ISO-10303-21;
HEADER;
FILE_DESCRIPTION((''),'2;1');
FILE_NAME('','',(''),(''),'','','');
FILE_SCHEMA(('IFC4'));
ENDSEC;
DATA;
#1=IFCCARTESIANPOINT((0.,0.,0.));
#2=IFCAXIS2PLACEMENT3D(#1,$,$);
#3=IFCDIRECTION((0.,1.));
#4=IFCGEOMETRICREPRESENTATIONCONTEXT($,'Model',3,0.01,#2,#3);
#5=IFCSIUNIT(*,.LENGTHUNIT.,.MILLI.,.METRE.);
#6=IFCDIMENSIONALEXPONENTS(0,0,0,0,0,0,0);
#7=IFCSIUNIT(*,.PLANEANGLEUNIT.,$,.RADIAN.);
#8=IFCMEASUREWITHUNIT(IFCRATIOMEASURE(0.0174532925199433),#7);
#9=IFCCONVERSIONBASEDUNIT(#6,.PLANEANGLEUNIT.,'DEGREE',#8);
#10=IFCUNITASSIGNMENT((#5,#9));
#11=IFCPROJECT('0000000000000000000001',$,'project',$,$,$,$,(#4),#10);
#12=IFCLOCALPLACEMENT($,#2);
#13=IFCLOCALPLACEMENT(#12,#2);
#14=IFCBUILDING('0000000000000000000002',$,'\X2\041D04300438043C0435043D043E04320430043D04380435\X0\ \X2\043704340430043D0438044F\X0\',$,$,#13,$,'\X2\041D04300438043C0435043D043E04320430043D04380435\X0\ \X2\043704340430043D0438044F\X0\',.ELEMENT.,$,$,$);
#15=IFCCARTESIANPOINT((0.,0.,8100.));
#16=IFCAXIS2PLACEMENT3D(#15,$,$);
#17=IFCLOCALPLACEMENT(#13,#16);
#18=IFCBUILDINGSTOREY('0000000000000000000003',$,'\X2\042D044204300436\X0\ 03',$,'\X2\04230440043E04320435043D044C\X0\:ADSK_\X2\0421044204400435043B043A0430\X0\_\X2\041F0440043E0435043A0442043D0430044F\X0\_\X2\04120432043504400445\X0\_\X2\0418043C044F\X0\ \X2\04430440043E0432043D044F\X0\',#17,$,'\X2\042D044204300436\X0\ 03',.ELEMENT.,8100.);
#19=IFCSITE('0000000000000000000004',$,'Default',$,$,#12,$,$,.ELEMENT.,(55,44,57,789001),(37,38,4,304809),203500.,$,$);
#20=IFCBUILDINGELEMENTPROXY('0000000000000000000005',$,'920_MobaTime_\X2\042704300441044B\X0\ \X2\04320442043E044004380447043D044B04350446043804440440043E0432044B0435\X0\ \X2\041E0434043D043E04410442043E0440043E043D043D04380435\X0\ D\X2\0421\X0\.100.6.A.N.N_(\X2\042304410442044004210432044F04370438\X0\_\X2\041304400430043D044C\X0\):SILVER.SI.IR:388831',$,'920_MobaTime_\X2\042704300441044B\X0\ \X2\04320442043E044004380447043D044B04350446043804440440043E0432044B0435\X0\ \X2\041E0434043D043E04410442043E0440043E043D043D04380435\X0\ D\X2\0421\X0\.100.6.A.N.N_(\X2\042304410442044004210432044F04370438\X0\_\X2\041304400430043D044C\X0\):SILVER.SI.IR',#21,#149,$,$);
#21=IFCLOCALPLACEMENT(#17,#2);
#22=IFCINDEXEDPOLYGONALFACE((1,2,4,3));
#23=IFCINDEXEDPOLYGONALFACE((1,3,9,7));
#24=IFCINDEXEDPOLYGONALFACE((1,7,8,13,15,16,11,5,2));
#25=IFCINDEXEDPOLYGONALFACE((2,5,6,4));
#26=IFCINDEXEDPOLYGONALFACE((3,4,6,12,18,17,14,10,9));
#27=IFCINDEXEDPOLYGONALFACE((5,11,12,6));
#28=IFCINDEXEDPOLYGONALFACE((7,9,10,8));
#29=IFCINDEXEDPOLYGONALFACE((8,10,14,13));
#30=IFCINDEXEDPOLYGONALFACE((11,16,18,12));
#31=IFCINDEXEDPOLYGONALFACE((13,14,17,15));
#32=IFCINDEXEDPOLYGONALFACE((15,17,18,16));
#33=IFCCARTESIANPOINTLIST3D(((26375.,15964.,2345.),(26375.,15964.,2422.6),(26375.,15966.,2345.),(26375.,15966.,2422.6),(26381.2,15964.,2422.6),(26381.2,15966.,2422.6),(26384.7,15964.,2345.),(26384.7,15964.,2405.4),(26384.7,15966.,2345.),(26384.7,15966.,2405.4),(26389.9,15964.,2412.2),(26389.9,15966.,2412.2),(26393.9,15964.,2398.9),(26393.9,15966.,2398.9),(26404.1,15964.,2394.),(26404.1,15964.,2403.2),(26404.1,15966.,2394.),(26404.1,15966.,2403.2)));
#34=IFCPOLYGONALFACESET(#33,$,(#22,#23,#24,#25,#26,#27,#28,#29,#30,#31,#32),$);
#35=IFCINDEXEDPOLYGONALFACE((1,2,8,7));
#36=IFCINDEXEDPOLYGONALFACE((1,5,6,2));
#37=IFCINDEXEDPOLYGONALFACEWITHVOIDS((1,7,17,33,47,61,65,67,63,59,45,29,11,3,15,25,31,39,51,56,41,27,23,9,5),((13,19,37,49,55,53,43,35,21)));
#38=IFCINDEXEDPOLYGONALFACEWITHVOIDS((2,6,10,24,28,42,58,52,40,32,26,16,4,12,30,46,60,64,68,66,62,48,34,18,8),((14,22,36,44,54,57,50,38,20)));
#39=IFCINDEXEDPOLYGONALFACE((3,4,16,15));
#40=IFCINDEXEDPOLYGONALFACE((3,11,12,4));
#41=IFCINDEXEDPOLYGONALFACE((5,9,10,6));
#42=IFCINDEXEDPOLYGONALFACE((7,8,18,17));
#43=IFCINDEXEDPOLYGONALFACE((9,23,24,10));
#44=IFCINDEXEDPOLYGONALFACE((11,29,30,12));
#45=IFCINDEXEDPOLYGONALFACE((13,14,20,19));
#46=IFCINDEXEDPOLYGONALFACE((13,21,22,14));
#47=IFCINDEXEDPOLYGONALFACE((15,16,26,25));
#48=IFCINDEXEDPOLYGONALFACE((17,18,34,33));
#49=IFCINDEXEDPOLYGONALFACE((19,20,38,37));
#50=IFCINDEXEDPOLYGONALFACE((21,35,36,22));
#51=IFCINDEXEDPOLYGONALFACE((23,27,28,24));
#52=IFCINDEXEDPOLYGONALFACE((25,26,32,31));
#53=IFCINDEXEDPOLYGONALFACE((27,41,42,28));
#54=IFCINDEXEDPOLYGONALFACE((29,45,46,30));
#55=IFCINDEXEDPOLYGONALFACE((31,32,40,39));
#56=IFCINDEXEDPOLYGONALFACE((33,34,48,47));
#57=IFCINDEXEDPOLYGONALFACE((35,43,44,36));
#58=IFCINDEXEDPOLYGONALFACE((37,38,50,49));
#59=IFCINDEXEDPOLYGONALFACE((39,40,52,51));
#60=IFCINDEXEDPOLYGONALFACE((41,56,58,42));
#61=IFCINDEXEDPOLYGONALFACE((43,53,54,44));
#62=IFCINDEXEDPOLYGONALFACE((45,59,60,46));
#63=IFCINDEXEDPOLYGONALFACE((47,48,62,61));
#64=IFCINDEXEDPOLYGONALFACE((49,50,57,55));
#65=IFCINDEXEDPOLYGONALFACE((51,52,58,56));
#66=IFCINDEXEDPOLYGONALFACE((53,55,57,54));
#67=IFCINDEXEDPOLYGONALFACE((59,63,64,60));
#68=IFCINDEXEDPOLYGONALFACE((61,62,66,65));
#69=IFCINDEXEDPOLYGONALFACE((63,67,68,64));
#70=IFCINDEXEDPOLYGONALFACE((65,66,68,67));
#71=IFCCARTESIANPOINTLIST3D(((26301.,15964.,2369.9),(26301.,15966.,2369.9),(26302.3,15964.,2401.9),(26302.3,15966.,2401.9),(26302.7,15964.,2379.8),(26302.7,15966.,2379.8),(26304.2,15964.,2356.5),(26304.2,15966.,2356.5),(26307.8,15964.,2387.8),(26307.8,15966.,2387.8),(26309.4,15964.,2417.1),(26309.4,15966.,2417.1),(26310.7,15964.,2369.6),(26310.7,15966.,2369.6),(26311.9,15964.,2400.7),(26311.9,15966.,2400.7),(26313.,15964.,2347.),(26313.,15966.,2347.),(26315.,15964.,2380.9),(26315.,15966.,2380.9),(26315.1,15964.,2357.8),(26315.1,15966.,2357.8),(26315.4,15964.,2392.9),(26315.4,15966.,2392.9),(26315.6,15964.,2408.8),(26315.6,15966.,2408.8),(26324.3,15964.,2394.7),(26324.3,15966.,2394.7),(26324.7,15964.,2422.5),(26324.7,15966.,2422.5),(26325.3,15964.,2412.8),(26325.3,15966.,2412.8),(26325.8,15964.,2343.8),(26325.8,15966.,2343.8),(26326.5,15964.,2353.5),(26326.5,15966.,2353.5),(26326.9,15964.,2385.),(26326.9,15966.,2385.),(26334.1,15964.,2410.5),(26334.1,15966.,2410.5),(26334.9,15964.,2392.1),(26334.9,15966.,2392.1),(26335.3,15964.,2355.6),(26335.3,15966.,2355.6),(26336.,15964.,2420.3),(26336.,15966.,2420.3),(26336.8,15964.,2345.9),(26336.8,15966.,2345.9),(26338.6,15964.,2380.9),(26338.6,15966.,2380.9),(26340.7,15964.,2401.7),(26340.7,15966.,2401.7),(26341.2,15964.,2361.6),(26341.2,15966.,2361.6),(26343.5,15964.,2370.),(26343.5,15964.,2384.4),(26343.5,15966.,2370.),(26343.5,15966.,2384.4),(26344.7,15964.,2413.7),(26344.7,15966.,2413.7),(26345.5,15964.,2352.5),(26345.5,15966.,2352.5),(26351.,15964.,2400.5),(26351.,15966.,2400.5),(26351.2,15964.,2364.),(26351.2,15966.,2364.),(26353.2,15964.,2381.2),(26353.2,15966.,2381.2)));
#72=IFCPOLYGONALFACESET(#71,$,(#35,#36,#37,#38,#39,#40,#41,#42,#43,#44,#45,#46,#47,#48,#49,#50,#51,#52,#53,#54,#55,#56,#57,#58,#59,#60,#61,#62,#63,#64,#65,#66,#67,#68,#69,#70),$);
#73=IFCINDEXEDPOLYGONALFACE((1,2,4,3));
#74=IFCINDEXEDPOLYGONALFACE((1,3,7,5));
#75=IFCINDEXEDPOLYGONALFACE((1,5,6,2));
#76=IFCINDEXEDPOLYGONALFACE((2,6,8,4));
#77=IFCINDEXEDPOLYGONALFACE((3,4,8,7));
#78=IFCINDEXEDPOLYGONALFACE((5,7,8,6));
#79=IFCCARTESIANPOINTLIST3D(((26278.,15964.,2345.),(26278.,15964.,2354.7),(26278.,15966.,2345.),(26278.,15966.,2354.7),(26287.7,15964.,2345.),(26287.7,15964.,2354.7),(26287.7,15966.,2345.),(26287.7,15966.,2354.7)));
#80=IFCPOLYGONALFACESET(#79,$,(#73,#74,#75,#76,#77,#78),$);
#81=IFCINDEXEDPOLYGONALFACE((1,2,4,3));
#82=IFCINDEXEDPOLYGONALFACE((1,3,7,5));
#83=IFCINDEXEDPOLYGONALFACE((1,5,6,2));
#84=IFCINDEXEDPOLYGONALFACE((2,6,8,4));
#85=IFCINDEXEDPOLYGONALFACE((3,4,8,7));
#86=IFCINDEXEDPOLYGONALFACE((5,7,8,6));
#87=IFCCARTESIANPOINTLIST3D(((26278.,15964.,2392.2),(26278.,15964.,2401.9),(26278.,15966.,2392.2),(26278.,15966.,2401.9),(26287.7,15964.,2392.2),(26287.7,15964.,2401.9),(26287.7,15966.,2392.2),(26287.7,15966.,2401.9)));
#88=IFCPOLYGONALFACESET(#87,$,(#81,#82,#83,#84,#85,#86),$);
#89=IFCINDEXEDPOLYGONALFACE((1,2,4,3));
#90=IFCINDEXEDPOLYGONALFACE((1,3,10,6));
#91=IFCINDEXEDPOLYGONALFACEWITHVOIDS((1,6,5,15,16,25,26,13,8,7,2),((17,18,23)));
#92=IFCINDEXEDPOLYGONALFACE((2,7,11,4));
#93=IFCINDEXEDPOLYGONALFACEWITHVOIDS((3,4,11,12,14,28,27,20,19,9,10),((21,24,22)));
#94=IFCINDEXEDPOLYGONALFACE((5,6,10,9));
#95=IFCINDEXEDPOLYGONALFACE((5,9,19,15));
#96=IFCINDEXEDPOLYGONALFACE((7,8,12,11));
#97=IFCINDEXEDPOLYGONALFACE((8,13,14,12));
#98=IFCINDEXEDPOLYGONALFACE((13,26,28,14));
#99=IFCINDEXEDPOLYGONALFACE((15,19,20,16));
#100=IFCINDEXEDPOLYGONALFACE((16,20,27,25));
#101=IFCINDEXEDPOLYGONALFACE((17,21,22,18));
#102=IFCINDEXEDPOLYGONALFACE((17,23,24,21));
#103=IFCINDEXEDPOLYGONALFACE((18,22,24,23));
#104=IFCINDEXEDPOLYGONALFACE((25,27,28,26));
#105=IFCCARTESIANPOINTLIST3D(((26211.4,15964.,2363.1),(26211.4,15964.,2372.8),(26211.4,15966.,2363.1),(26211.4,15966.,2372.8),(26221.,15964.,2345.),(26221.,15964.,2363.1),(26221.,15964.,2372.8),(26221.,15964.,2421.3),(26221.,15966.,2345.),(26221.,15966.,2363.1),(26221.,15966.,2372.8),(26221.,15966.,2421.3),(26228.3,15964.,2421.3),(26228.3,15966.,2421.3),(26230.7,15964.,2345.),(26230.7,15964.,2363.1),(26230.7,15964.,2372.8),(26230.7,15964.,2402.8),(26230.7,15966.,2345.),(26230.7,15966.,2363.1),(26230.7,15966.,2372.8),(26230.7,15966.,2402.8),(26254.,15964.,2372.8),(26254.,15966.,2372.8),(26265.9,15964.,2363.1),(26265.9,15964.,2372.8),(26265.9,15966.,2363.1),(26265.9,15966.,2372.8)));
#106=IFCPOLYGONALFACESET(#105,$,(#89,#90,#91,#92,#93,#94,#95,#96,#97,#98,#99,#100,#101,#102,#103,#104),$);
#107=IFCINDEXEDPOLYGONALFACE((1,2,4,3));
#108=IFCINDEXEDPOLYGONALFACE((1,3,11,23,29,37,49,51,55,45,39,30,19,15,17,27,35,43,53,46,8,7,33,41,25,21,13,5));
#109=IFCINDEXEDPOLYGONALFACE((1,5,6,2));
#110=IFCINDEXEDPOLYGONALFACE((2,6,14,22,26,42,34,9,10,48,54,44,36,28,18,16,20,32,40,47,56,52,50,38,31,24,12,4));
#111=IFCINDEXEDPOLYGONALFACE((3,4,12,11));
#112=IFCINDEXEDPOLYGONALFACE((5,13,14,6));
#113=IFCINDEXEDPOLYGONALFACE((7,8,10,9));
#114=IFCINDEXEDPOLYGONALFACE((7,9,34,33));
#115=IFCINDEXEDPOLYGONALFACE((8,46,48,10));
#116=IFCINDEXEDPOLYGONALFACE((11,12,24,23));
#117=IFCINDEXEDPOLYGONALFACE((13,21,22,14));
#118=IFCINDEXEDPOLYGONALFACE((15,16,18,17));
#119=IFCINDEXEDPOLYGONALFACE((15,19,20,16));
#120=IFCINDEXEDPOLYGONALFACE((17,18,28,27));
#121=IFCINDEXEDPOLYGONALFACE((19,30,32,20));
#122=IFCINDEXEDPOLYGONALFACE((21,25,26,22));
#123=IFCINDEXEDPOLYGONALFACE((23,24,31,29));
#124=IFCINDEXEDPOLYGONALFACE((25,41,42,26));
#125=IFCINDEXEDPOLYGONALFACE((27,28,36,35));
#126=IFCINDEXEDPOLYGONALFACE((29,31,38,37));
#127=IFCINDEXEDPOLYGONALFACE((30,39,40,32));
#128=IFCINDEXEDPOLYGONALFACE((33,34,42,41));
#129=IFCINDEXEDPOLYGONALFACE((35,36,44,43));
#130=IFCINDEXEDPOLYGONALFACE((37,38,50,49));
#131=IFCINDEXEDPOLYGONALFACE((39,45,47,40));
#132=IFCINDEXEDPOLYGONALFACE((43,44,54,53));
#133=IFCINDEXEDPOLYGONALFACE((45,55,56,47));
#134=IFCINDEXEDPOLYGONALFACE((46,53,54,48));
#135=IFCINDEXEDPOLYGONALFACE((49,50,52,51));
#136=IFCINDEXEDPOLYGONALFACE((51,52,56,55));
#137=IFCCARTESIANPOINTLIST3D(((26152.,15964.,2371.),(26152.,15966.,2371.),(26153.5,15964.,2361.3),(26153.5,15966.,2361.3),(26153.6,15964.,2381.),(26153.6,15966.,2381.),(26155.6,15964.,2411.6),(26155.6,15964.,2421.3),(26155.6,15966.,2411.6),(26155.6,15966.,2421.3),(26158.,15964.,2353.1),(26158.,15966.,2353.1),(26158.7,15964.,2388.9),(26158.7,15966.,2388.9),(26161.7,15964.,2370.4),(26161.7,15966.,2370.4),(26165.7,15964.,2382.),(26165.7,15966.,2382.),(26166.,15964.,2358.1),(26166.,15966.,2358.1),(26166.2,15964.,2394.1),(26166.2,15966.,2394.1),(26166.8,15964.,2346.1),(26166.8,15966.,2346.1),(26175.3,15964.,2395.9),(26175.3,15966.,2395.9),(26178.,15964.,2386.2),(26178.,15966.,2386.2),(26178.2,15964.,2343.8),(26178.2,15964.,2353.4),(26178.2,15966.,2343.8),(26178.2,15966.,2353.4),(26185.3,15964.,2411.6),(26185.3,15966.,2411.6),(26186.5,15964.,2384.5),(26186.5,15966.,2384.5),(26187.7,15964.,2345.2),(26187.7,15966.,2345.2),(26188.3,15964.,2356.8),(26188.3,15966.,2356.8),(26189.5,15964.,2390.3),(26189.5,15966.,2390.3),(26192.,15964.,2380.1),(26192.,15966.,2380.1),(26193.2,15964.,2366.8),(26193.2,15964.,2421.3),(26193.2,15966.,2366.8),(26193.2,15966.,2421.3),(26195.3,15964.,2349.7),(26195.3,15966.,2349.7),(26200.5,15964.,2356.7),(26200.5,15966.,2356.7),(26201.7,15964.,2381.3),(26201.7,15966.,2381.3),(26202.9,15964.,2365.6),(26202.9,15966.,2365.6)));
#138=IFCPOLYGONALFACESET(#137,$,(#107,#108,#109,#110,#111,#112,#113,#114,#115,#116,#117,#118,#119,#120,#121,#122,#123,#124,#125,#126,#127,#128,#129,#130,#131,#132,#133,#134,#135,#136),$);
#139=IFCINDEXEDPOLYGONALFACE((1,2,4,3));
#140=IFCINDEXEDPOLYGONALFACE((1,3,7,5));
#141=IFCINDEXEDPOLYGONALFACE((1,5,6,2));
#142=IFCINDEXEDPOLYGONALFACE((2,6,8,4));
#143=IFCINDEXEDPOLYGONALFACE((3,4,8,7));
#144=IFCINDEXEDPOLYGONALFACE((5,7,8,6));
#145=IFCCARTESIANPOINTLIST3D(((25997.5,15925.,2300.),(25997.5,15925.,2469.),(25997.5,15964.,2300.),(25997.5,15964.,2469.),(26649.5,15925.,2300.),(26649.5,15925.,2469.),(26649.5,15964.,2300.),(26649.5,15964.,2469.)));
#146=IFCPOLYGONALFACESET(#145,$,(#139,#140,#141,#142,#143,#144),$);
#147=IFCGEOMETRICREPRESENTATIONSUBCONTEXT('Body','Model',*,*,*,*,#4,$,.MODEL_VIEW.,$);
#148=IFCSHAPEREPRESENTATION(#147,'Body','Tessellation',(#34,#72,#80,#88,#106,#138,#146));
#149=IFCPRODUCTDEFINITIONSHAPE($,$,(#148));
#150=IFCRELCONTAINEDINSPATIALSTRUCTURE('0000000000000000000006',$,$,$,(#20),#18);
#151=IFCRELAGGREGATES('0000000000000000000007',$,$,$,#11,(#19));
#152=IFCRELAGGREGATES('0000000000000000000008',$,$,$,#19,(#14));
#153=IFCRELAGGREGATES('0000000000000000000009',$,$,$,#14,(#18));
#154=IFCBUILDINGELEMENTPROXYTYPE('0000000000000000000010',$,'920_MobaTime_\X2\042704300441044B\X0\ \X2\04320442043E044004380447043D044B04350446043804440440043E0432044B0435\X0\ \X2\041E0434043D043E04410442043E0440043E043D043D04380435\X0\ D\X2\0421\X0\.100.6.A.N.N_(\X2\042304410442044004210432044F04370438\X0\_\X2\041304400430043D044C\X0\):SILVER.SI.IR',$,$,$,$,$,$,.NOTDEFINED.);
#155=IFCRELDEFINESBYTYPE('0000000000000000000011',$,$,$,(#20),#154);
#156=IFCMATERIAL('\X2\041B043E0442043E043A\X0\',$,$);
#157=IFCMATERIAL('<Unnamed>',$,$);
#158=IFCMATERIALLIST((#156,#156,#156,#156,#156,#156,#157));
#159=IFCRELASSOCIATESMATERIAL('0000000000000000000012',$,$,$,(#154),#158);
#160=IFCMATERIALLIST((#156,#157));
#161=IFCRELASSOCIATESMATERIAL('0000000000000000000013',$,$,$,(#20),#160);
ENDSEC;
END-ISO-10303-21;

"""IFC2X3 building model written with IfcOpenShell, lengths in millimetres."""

from ifc_helpers import new_model, entity, si_unit, converted_unit, direction, frame, origin, origin_2d_with_axis, place, context, subcontext, project, spatial, polyline, rectangle, outline, extrude, source, transform, mapped, material, material_list, type_object, type_shapes, element, save


model = new_model("IFC2X3")

# Units and contexts
model_context = context("Model", 3, precision=0.01, world=origin(), true_north=direction((0.0, 1.0)))
body_context = subcontext(model_context, "Body", "Model", "MODEL_VIEW")
ifc_project = project(units=[si_unit("LENGTHUNIT", "METRE", prefix="MILLI"), converted_unit("PLANEANGLEUNIT", "DEGREE", entity("IfcRatioMeasure", 0.0174532925199433), si_unit("PLANEANGLEUNIT", "RADIAN"), dimensions=[0, 0, 0, 0, 0, 0, 0])], contexts=[model_context])

# Site, building, storey
site_placement = place(None, origin())
site = spatial("IfcSite", under=ifc_project, at=site_placement, Name="Default", CompositionType="ELEMENT", RefLatitude=(55, 44, 57, 789001), RefLongitude=(37, 38, 4, 304809), RefElevation=203500.0)
building_placement = place(site_placement, origin())
building = spatial("IfcBuilding", under=site, at=building_placement, Name="Наименование здания", LongName="Наименование здания", CompositionType="ELEMENT")
storey_placement = place(building_placement, frame((0.0, 0.0, 8100.0)))
storey = spatial("IfcBuildingStorey", under=building, at=storey_placement, Name="Этаж 03", ObjectType="Уровень:ADSK_Стрелка_Проектная_Вверх_Имя уровня", LongName="Этаж 03", CompositionType="ELEMENT", Elevation=8100.0)

# Building element proxy
ifc_material_1 = material(Name="Лоток")
ifc_material_2 = material(Name="<Unnamed>")
ifc_material_list_1 = material_list([ifc_material_1, ifc_material_1, ifc_material_1, ifc_material_1, ifc_material_1, ifc_material_1, ifc_material_2])
building_element_proxy_type = type_object("IfcBuildingElementProxyType", Name="920_MobaTime_Часы вторичныецифровые Односторонние DС.100.6.A.N.N_(УстрСвязи_Грань):SILVER.SI.IR", PredefinedType="NOTDEFINED", material=ifc_material_list_1)
shared_shape = source(origin(), body_context, "Body", "SweptSolid", [
    extrude(outline(polyline([(-49.3, -13.1), (28.2, -13.1), (28.2, -6.8), (17.9, 1.8), (8.8, 16.0), (-0.3, 16.0), (4.6, 5.8), (11.1, -3.4), (-49.3, -3.4), (-49.3, -13.1)])), frame((-64.6, 9.8, 39.0), z_axis=(0.0, 0.0, 1.0), x_axis=(0.0, 1.0, 0.0)), (0.0, 0.0, 1.0), 2.0),
    extrude(outline(polyline([(2.2, -27.6), (19.0, -27.6), (30.5, -16.1), (33.3, -4.9), (31.0, 5.8), (21.8, 17.2), (5.2, 27.3), (-11.1, 33.0), (-24.0, 32.7), (-33.6, 27.6), (-40.3, 18.6), (-42.8, 5.7), (-38.0, -6.3), (-27.2, -14.9), (-17.5, -17.7), (-8.2, -16.4), (-0.3, -11.9), (5.1, -4.5), (7.3, 6.2), (4.0, 17.2), (18.4, 7.3), (23.6, -2.4), (22.0, -11.4), (14.2, -18.4), (5.3, -18.3), (2.2, -27.6)]), holes=[polyline([(-9.0, 23.3), (-1.3, 14.3), (-2.5, 2.0), (-11.4, -7.0), (-23.4, -6.0), (-32.2, 2.9), (-31.2, 15.1), (-25.6, 22.1), (-17.5, 24.9), (-9.0, 23.3)])]), frame((-2.7, 3.6, 39.0), z_axis=(0.0, 0.0, 1.0), x_axis=(-0.427649, 0.903945, 0.0)), (0.0, 0.0, 1.0), 2.0),
    extrude(rectangle(XDim=9.7, YDim=9.7, at=origin_2d_with_axis()), frame((40.6, -34.7, 39.0)), (0.0, 0.0, 1.0), 2.0),
    extrude(rectangle(XDim=9.7, YDim=9.7, at=origin_2d_with_axis()), frame((40.6, 12.6, 39.0)), (0.0, 0.0, 1.0), 2.0),
    extrude(outline(polyline([(-0.9, -28.1), (8.8, -28.1), (8.8, -9.9), (18.5, -9.9), (18.5, -0.2), (8.8, -0.2), (8.8, 48.3), (1.5, 48.3), (-36.0, -0.2), (-36.0, -9.9), (-0.9, -9.9), (-0.9, -28.1)]), holes=[polyline([(-0.9, -0.2), (-24.1, -0.2), (-0.9, 29.7), (-0.9, -0.2)])]), frame((93.6, -11.4, 39.0)), (0.0, 0.0, 1.0), 2.0),
    extrude(outline(polyline([(3.3, -28.3), (12.5, -28.3), (20.5, -25.0), (26.8, -18.9), (30.7, -10.0), (31.4, 1.6), (26.9, 11.8), (20.1, 18.4), (11.1, 22.3), (1.0, 23.3), (-7.9, 20.4), (-14.9, 14.5), (-18.9, 6.2), (-17.1, -9.0), (-36.7, 0.5), (-29.1, 29.2), (-38.5, 31.7), (-48.1, -4.6), (-11.6, -23.1), (-8.0, -14.0), (-10.8, -7.6), (-10.2, 1.1), (-3.0, 11.8), (9.2, 12.8), (20.0, 5.5), (21.4, -7.5), (15.5, -16.4), (4.6, -18.6), (3.3, -28.3)])), frame((147.1, -8.5, 39.0), z_axis=(0.0, 0.0, 1.0), x_axis=(0.256974, -0.966418, 0.0)), (0.0, 0.0, 1.0), 2.0),
    extrude(rectangle(XDim=652.0, YDim=169.0, at=origin_2d_with_axis()), frame((0.0, 0.0, 0.0), z_axis=(0.0, 0.0, 1.0), x_axis=(-1.0, 0.0, 0.0)), (0.0, 0.0, 1.0), 39.0),
])
type_shapes(building_element_proxy_type, [shared_shape])
ifc_material_list_2 = material_list([ifc_material_1, ifc_material_2])
for number, where, z_axis, x_axis, name in (
    (1, (26323.5, 15925.0, 2384.5), (0.0, 1.0, 0.0), (-1.0, 0.0, 0.0), "920_MobaTime_Часы вторичныецифровые Односторонние DС.100.6.A.N.N_(УстрСвязи_Грань):SILVER.SI.IR:388831"),
):
    element("IfcBuildingElementProxy", number, at=place(storey_placement, frame(where, z_axis=z_axis, x_axis=x_axis)), inside=storey, type_object=building_element_proxy_type, material=ifc_material_list_2, Name=name, ObjectType="920_MobaTime_Часы вторичныецифровые Односторонние DС.100.6.A.N.N_(УстрСвязи_Грань):SILVER.SI.IR", context=body_context, shape_type="MappedRepresentation", body=[
        mapped(shared_shape, transform((0.0, 0.0, 0.0), scale=1.0)),
    ])

save(model, "model.ifc")
